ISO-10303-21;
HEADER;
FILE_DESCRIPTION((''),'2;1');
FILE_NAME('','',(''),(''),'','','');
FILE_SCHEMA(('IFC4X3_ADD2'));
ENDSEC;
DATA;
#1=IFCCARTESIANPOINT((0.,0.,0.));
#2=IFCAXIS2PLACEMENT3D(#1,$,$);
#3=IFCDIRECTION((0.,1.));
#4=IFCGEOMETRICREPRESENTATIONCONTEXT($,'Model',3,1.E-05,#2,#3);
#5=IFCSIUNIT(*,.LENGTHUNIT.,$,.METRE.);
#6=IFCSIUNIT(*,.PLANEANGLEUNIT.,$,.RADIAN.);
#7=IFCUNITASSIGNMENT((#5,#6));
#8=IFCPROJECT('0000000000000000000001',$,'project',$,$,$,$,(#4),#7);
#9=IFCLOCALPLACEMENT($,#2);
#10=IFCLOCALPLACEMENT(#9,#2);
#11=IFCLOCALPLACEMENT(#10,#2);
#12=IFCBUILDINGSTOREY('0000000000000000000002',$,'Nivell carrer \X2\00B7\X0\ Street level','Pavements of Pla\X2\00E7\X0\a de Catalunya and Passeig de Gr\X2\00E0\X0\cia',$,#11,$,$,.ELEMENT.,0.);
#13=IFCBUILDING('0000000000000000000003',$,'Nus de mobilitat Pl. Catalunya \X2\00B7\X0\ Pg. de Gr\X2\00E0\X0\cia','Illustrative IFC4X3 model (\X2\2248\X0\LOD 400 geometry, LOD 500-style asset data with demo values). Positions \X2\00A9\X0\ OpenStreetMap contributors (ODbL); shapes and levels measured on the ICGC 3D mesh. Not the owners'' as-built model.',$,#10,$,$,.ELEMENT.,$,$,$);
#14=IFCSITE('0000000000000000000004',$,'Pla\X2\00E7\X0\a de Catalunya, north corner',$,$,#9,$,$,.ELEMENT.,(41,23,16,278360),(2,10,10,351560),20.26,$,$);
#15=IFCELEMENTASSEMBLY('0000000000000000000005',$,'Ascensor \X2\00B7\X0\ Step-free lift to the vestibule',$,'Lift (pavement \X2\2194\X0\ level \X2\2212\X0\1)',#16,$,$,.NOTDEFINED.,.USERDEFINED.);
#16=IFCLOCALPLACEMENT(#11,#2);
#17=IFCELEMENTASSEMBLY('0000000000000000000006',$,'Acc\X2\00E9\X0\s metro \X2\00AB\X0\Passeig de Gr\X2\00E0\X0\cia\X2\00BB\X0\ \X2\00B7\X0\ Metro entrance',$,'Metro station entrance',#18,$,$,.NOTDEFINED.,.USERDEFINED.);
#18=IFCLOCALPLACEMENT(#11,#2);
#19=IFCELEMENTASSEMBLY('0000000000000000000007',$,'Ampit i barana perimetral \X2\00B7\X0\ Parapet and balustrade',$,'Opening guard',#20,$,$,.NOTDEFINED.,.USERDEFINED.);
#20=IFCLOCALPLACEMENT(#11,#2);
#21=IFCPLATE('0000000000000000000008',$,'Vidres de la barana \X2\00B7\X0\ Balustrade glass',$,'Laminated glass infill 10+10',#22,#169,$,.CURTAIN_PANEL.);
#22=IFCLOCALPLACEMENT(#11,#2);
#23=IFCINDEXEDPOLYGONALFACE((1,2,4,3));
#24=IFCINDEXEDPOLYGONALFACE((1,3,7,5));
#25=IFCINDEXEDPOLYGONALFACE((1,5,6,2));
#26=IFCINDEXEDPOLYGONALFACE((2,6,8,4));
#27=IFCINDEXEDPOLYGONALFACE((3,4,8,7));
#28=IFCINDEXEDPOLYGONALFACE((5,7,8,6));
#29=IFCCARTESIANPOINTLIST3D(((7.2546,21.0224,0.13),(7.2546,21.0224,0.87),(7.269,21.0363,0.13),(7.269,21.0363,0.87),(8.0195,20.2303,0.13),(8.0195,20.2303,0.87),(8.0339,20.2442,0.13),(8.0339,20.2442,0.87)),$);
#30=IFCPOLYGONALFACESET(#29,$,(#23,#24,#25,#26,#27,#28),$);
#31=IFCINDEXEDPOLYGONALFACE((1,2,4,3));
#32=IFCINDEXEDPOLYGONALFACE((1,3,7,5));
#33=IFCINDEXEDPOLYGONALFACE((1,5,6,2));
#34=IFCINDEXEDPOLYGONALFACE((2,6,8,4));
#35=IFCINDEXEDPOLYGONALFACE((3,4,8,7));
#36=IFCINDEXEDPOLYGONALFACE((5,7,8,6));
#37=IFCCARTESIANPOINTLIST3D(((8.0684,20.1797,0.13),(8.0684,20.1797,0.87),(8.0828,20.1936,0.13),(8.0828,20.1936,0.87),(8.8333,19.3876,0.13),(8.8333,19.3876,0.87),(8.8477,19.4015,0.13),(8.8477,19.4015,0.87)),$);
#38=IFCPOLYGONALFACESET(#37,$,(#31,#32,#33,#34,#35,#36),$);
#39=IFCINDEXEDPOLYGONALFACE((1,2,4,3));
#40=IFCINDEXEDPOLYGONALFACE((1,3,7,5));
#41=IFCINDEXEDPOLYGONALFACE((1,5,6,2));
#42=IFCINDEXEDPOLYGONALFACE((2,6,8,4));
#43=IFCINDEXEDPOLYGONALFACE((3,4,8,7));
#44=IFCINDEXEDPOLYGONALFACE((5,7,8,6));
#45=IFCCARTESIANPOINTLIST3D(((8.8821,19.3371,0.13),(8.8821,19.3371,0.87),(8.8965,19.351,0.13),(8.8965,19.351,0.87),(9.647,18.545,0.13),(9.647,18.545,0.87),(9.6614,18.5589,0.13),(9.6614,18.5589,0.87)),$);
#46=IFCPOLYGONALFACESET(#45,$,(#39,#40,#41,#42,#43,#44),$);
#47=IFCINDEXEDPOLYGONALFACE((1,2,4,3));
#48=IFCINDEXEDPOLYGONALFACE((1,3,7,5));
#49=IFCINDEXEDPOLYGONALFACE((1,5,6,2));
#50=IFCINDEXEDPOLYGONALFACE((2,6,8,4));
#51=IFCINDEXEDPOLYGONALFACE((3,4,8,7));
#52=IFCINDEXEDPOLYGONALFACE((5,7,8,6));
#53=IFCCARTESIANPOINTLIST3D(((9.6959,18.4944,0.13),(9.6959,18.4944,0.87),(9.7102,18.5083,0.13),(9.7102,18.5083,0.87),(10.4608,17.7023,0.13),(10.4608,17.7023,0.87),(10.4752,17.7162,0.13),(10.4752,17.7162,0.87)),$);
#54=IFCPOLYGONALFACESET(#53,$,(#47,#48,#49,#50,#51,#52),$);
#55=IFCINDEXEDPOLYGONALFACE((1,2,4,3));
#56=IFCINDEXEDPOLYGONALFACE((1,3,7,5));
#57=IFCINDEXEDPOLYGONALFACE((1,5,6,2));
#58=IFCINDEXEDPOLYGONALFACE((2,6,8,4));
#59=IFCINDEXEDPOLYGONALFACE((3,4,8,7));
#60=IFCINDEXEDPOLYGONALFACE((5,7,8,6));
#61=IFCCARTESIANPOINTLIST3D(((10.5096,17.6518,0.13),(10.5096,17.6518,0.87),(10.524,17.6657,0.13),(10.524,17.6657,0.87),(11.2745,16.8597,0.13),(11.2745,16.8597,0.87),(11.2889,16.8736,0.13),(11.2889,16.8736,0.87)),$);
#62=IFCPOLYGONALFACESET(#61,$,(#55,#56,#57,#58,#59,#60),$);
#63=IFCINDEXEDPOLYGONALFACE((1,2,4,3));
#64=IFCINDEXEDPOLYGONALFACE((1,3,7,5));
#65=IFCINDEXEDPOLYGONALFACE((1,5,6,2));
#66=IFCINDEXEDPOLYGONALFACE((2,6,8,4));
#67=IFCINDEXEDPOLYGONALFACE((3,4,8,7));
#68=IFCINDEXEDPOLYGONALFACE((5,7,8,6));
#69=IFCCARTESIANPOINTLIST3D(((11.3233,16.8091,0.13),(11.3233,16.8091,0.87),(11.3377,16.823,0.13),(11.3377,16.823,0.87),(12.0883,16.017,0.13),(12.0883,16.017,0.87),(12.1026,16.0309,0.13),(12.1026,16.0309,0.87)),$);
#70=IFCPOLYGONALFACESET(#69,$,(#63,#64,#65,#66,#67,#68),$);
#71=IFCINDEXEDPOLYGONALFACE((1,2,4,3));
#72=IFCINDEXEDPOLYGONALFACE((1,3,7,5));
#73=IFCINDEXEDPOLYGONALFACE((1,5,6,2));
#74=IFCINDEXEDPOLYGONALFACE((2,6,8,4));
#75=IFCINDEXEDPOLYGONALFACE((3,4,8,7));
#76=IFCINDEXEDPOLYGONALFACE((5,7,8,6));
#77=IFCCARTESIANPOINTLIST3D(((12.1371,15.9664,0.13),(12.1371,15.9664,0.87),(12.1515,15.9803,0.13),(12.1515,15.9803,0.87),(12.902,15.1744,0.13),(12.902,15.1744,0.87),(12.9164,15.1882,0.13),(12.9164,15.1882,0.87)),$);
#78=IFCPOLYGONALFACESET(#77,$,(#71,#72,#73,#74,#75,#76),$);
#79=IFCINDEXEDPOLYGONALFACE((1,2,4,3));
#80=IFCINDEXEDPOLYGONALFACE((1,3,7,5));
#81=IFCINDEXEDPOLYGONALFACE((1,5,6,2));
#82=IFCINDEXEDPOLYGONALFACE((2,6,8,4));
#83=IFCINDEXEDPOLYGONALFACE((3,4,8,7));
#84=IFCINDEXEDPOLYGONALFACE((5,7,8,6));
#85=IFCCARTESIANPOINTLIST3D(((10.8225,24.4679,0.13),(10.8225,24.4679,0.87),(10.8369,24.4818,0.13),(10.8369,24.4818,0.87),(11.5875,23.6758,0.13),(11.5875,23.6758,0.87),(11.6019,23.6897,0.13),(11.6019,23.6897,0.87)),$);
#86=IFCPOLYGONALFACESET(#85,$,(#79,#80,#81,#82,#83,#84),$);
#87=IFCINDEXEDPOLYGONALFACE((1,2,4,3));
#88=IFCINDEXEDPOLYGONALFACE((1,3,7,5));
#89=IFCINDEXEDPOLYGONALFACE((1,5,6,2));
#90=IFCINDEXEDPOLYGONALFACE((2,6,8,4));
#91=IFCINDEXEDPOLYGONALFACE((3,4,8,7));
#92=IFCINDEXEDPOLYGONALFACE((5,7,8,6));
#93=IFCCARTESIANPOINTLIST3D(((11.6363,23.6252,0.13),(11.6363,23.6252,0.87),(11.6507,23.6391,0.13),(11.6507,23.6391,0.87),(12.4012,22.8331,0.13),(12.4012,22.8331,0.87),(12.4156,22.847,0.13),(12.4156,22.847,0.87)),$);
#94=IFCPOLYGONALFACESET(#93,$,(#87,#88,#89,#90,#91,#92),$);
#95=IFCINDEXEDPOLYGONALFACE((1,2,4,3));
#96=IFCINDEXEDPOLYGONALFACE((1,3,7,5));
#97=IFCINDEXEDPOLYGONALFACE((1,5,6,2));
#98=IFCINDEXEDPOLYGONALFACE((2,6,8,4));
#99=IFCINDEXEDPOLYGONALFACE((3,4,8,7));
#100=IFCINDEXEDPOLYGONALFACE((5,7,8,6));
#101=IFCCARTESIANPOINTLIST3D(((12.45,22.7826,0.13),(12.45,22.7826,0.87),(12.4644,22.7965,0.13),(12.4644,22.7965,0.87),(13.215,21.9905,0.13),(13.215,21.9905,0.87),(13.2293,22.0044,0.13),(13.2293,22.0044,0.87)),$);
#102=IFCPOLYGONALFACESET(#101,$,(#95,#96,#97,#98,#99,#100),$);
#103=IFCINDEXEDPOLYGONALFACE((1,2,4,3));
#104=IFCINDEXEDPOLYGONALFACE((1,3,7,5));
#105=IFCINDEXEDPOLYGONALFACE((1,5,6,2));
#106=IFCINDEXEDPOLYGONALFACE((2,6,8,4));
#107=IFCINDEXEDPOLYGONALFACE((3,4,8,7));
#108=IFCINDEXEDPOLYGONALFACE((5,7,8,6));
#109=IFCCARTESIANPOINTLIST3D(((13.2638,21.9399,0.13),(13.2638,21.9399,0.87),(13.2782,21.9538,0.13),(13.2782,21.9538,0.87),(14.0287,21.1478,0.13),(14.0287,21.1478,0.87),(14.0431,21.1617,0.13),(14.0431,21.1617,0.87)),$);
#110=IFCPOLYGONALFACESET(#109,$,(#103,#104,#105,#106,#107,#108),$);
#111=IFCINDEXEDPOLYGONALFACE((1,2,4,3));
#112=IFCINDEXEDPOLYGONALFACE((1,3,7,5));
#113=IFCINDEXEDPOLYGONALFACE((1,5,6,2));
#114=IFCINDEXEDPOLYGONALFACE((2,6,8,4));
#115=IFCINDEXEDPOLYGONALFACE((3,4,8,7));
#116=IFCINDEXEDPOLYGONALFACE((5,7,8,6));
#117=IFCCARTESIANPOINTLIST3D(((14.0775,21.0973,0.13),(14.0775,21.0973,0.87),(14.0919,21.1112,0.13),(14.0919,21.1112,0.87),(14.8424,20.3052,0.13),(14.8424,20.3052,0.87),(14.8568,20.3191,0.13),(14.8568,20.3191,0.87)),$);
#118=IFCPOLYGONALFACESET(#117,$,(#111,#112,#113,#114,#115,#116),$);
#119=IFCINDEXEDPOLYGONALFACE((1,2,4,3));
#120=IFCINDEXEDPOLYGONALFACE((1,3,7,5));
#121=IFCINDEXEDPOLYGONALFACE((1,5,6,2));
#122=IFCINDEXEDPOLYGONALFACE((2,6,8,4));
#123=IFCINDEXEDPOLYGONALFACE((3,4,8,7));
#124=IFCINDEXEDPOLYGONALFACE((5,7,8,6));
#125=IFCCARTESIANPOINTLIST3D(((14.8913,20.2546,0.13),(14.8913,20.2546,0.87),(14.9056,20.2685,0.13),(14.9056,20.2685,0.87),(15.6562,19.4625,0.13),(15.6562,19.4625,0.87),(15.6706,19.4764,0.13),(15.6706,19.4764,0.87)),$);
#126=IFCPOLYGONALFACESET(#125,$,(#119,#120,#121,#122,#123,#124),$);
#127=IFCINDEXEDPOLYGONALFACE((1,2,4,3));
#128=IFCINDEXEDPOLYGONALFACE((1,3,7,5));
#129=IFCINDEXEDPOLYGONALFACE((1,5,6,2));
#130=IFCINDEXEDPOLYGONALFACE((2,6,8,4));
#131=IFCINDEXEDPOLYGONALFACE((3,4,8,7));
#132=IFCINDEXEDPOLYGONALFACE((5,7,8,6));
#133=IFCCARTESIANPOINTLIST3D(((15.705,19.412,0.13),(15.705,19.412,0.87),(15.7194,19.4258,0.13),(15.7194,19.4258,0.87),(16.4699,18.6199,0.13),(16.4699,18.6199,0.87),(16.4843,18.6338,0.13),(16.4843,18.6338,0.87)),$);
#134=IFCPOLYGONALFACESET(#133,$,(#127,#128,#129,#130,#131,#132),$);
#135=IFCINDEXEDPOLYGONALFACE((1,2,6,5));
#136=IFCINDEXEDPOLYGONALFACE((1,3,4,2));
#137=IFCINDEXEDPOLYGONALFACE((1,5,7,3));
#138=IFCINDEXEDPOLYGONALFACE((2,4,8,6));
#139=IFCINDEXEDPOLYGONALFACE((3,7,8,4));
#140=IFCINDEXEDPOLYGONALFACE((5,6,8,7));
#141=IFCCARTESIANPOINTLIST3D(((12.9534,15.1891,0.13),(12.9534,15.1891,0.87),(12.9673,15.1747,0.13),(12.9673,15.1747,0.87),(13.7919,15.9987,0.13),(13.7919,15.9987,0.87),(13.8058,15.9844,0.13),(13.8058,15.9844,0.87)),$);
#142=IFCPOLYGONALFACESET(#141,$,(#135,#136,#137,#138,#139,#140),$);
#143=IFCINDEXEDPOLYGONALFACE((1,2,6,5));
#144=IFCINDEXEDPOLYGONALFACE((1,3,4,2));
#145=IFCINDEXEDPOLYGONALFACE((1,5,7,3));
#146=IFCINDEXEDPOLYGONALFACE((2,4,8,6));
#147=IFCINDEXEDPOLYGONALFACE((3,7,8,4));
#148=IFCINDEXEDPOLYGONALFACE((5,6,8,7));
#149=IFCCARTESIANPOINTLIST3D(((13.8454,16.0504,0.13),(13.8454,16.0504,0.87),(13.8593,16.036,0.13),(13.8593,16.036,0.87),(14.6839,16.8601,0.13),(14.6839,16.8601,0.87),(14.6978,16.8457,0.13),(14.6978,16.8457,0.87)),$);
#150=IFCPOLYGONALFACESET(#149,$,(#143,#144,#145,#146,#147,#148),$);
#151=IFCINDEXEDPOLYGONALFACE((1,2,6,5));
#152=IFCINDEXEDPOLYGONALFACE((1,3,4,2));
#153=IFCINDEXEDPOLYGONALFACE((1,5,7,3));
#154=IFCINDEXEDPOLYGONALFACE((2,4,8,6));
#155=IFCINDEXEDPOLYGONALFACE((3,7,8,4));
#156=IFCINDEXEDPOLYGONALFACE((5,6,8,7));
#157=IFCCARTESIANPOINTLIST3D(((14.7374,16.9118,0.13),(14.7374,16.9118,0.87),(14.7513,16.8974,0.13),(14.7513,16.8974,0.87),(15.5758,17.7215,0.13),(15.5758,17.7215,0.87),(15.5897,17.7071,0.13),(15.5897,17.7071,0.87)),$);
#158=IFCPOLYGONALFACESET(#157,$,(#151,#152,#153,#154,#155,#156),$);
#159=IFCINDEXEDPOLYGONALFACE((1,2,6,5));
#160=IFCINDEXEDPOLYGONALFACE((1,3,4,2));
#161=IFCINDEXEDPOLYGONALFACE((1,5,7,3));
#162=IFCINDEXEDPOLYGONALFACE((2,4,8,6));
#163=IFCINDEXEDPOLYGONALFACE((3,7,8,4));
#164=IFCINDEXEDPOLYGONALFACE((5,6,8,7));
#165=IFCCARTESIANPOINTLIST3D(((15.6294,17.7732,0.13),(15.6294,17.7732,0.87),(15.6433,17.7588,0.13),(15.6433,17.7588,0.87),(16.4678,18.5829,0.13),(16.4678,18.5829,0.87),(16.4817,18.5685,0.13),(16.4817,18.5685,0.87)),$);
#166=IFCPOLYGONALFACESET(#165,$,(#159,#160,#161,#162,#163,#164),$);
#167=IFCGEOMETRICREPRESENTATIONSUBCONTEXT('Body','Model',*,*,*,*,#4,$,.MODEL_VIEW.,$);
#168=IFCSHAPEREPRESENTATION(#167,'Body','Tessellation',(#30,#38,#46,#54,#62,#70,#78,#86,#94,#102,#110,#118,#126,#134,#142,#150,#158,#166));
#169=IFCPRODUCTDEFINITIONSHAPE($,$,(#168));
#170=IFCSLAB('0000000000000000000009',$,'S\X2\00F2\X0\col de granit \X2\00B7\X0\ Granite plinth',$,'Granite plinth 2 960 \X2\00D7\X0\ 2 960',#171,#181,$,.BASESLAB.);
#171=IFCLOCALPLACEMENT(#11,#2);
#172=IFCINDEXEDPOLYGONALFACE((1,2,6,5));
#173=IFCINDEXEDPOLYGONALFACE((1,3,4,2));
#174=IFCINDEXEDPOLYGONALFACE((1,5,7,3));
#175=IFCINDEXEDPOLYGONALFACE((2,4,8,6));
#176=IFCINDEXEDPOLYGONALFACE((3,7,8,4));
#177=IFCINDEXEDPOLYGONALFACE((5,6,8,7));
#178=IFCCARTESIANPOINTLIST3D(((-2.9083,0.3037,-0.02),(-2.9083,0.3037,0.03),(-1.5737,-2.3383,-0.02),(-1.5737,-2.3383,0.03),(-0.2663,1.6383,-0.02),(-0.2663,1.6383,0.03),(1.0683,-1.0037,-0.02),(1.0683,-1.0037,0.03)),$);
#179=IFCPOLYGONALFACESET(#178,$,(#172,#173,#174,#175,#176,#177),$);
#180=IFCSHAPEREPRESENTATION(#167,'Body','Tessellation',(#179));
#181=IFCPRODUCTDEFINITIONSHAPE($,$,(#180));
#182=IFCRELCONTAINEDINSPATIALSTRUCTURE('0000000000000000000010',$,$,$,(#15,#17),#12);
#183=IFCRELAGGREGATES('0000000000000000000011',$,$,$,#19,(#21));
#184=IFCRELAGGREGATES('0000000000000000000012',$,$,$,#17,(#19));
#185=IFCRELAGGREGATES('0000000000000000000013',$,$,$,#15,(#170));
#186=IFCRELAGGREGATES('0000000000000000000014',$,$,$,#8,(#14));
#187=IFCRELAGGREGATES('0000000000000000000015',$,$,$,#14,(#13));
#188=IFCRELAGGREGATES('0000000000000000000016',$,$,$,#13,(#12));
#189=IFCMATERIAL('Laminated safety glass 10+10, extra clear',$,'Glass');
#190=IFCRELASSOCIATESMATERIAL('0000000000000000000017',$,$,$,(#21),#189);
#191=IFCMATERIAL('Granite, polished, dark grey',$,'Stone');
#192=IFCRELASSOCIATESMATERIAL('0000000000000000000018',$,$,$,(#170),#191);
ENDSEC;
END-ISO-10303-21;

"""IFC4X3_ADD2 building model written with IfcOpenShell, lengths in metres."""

from ifc_helpers import new_model, si_unit, direction, frame, frame_2d, origin, place, context, subcontext, project, spatial, rectangle, extrude, material, element, aggregate, save


model = new_model("IFC4X3_ADD2")

# Units and contexts
model_context = context("Model", 3, precision=1e-05, world=origin(), true_north=direction((0.0, 1.0)))
body_context = subcontext(model_context, "Body", "Model", "MODEL_VIEW")
ifc_project = project(units=[si_unit("LENGTHUNIT", "METRE"), si_unit("PLANEANGLEUNIT", "RADIAN")], contexts=[model_context])

# Site, building, storey
site_placement = place(None, origin())
site = spatial("IfcSite", under=ifc_project, at=site_placement, Name="Plaça de Catalunya, north corner", CompositionType="ELEMENT", RefLatitude=(41, 23, 16, 278360), RefLongitude=(2, 10, 10, 351560), RefElevation=20.26)
building_placement = place(site_placement, origin())
building = spatial("IfcBuilding", under=site, at=building_placement, Name="Nus de mobilitat Pl. Catalunya · Pg. de Gràcia", Description="Illustrative IFC4X3 model (≈LOD 400 geometry, LOD 500-style asset data with demo values). Positions © OpenStreetMap contributors (ODbL); shapes and levels measured on the ICGC 3D mesh. Not the owners' as-built model.", CompositionType="ELEMENT")
storey_placement = place(building_placement, origin())
storey = spatial("IfcBuildingStorey", under=building, at=storey_placement, Name="Nivell carrer · Street level", Description="Pavements of Plaça de Catalunya and Passeig de Gràcia", CompositionType="ELEMENT", Elevation=0.0)

# Element assembly
assembly_1_placement = place(building_placement, origin())
assembly_1 = element("IfcElementAssembly", 1, at=assembly_1_placement, inside=storey, Name="Ascensor · Step-free lift to the vestibule", ObjectType="Lift (pavement ↔ level −1)", AssemblyPlace="NOTDEFINED", PredefinedType="USERDEFINED")

# Element assemblies
assembly_2_placement = place(building_placement, origin())
assembly_2 = element("IfcElementAssembly", 2, at=assembly_2_placement, inside=storey, Name="Accés metro «Passeig de Gràcia» · Metro entrance", ObjectType="Metro station entrance", AssemblyPlace="NOTDEFINED", PredefinedType="USERDEFINED")
assembly_3_placement = place(building_placement, origin())
assembly_3 = element("IfcElementAssembly", 3, at=assembly_3_placement, Name="Ampit i barana perimetral · Parapet and balustrade", ObjectType="Opening guard", AssemblyPlace="NOTDEFINED", PredefinedType="USERDEFINED")

# Plate
ifc_material_1 = material(Name="Laminated safety glass 10+10, extra clear", Category="Glass")
plate_1_placement = place(building_placement, origin())
plate_1 = element("IfcPlate", 4, at=plate_1_placement, material=ifc_material_1, Name="Vidres de la barana · Balustrade glass", ObjectType="Laminated glass infill 10+10", PredefinedType="CURTAIN_PANEL", context=body_context, shape_type="SweptSolid", body=[
    extrude(rectangle(XDim=1.1011, YDim=0.02, at=frame_2d((0.0, 0.0), x_axis=(0.694658, -0.71934))), frame((7.6443, 20.6333, 0.13)), (0.0, 0.0, 1.0), 0.74),
    extrude(rectangle(XDim=1.1011, YDim=0.02, at=frame_2d((0.0, 0.0), x_axis=(0.694658, -0.71934))), frame((8.458, 19.7906, 0.13)), (0.0, 0.0, 1.0), 0.74),
    extrude(rectangle(XDim=1.1011, YDim=0.02, at=frame_2d((0.0, 0.0), x_axis=(0.694658, -0.71934))), frame((9.2718, 18.948, 0.13)), (0.0, 0.0, 1.0), 0.74),
    extrude(rectangle(XDim=1.1011, YDim=0.02, at=frame_2d((0.0, 0.0), x_axis=(0.694658, -0.71934))), frame((10.0855, 18.1053, 0.13)), (0.0, 0.0, 1.0), 0.74),
    extrude(rectangle(XDim=1.1011, YDim=0.02, at=frame_2d((0.0, 0.0), x_axis=(0.694658, -0.71934))), frame((10.8992, 17.2627, 0.13)), (0.0, 0.0, 1.0), 0.74),
    extrude(rectangle(XDim=1.1011, YDim=0.02, at=frame_2d((0.0, 0.0), x_axis=(0.694658, -0.71934))), frame((11.713, 16.42, 0.13)), (0.0, 0.0, 1.0), 0.74),
    extrude(rectangle(XDim=1.1011, YDim=0.02, at=frame_2d((0.0, 0.0), x_axis=(0.694658, -0.71934))), frame((12.5267, 15.5773, 0.13)), (0.0, 0.0, 1.0), 0.74),
    extrude(rectangle(XDim=1.1011, YDim=0.02, at=frame_2d((0.0, 0.0), x_axis=(0.694658, -0.71934))), frame((11.2122, 24.0788, 0.13)), (0.0, 0.0, 1.0), 0.74),
    extrude(rectangle(XDim=1.1011, YDim=0.02, at=frame_2d((0.0, 0.0), x_axis=(0.694658, -0.71934))), frame((12.0259, 23.2361, 0.13)), (0.0, 0.0, 1.0), 0.74),
    extrude(rectangle(XDim=1.1011, YDim=0.02, at=frame_2d((0.0, 0.0), x_axis=(0.694658, -0.71934))), frame((12.8397, 22.3935, 0.13)), (0.0, 0.0, 1.0), 0.74),
    extrude(rectangle(XDim=1.1011, YDim=0.02, at=frame_2d((0.0, 0.0), x_axis=(0.694658, -0.71934))), frame((13.6534, 21.5508, 0.13)), (0.0, 0.0, 1.0), 0.74),
    extrude(rectangle(XDim=1.1011, YDim=0.02, at=frame_2d((0.0, 0.0), x_axis=(0.694658, -0.71934))), frame((14.4672, 20.7082, 0.13)), (0.0, 0.0, 1.0), 0.74),
    extrude(rectangle(XDim=1.1011, YDim=0.02, at=frame_2d((0.0, 0.0), x_axis=(0.694658, -0.71934))), frame((15.2809, 19.8655, 0.13)), (0.0, 0.0, 1.0), 0.74),
    extrude(rectangle(XDim=1.1011, YDim=0.02, at=frame_2d((0.0, 0.0), x_axis=(0.694658, -0.71934))), frame((16.0947, 19.0229, 0.13)), (0.0, 0.0, 1.0), 0.74),
    extrude(rectangle(XDim=1.1656, YDim=0.02, at=frame_2d((0.0, 0.0), x_axis=(0.71934, 0.694658))), frame((13.3796, 15.5867, 0.13)), (0.0, 0.0, 1.0), 0.74),
    extrude(rectangle(XDim=1.1656, YDim=0.02, at=frame_2d((0.0, 0.0), x_axis=(0.71934, 0.694658))), frame((14.2716, 16.4481, 0.13)), (0.0, 0.0, 1.0), 0.74),
    extrude(rectangle(XDim=1.1656, YDim=0.02, at=frame_2d((0.0, 0.0), x_axis=(0.71934, 0.694658))), frame((15.1636, 17.3095, 0.13)), (0.0, 0.0, 1.0), 0.74),
    extrude(rectangle(XDim=1.1656, YDim=0.02, at=frame_2d((0.0, 0.0), x_axis=(0.71934, 0.694658))), frame((16.0555, 18.1708, 0.13)), (0.0, 0.0, 1.0), 0.74),
])

# Slab
ifc_material_2 = material(Name="Granite, polished, dark grey", Category="Stone")
slab_placement = place(building_placement, origin())
slab = element("IfcSlab", 5, at=slab_placement, material=ifc_material_2, Name="Sòcol de granit · Granite plinth", ObjectType="Granite plinth 2 960 × 2 960", PredefinedType="BASESLAB", context=body_context, shape_type="SweptSolid", body=[
    extrude(rectangle(XDim=2.96, YDim=2.96, at=frame_2d((0.0, 0.0), x_axis=(0.892586, 0.450878))), frame((-0.92, -0.35, -0.02)), (0.0, 0.0, 1.0), 0.05),
])

aggregate(assembly_3, [plate_1])

aggregate(assembly_2, [assembly_3])

aggregate(assembly_1, [slab])

save(model, "model.ifc")
